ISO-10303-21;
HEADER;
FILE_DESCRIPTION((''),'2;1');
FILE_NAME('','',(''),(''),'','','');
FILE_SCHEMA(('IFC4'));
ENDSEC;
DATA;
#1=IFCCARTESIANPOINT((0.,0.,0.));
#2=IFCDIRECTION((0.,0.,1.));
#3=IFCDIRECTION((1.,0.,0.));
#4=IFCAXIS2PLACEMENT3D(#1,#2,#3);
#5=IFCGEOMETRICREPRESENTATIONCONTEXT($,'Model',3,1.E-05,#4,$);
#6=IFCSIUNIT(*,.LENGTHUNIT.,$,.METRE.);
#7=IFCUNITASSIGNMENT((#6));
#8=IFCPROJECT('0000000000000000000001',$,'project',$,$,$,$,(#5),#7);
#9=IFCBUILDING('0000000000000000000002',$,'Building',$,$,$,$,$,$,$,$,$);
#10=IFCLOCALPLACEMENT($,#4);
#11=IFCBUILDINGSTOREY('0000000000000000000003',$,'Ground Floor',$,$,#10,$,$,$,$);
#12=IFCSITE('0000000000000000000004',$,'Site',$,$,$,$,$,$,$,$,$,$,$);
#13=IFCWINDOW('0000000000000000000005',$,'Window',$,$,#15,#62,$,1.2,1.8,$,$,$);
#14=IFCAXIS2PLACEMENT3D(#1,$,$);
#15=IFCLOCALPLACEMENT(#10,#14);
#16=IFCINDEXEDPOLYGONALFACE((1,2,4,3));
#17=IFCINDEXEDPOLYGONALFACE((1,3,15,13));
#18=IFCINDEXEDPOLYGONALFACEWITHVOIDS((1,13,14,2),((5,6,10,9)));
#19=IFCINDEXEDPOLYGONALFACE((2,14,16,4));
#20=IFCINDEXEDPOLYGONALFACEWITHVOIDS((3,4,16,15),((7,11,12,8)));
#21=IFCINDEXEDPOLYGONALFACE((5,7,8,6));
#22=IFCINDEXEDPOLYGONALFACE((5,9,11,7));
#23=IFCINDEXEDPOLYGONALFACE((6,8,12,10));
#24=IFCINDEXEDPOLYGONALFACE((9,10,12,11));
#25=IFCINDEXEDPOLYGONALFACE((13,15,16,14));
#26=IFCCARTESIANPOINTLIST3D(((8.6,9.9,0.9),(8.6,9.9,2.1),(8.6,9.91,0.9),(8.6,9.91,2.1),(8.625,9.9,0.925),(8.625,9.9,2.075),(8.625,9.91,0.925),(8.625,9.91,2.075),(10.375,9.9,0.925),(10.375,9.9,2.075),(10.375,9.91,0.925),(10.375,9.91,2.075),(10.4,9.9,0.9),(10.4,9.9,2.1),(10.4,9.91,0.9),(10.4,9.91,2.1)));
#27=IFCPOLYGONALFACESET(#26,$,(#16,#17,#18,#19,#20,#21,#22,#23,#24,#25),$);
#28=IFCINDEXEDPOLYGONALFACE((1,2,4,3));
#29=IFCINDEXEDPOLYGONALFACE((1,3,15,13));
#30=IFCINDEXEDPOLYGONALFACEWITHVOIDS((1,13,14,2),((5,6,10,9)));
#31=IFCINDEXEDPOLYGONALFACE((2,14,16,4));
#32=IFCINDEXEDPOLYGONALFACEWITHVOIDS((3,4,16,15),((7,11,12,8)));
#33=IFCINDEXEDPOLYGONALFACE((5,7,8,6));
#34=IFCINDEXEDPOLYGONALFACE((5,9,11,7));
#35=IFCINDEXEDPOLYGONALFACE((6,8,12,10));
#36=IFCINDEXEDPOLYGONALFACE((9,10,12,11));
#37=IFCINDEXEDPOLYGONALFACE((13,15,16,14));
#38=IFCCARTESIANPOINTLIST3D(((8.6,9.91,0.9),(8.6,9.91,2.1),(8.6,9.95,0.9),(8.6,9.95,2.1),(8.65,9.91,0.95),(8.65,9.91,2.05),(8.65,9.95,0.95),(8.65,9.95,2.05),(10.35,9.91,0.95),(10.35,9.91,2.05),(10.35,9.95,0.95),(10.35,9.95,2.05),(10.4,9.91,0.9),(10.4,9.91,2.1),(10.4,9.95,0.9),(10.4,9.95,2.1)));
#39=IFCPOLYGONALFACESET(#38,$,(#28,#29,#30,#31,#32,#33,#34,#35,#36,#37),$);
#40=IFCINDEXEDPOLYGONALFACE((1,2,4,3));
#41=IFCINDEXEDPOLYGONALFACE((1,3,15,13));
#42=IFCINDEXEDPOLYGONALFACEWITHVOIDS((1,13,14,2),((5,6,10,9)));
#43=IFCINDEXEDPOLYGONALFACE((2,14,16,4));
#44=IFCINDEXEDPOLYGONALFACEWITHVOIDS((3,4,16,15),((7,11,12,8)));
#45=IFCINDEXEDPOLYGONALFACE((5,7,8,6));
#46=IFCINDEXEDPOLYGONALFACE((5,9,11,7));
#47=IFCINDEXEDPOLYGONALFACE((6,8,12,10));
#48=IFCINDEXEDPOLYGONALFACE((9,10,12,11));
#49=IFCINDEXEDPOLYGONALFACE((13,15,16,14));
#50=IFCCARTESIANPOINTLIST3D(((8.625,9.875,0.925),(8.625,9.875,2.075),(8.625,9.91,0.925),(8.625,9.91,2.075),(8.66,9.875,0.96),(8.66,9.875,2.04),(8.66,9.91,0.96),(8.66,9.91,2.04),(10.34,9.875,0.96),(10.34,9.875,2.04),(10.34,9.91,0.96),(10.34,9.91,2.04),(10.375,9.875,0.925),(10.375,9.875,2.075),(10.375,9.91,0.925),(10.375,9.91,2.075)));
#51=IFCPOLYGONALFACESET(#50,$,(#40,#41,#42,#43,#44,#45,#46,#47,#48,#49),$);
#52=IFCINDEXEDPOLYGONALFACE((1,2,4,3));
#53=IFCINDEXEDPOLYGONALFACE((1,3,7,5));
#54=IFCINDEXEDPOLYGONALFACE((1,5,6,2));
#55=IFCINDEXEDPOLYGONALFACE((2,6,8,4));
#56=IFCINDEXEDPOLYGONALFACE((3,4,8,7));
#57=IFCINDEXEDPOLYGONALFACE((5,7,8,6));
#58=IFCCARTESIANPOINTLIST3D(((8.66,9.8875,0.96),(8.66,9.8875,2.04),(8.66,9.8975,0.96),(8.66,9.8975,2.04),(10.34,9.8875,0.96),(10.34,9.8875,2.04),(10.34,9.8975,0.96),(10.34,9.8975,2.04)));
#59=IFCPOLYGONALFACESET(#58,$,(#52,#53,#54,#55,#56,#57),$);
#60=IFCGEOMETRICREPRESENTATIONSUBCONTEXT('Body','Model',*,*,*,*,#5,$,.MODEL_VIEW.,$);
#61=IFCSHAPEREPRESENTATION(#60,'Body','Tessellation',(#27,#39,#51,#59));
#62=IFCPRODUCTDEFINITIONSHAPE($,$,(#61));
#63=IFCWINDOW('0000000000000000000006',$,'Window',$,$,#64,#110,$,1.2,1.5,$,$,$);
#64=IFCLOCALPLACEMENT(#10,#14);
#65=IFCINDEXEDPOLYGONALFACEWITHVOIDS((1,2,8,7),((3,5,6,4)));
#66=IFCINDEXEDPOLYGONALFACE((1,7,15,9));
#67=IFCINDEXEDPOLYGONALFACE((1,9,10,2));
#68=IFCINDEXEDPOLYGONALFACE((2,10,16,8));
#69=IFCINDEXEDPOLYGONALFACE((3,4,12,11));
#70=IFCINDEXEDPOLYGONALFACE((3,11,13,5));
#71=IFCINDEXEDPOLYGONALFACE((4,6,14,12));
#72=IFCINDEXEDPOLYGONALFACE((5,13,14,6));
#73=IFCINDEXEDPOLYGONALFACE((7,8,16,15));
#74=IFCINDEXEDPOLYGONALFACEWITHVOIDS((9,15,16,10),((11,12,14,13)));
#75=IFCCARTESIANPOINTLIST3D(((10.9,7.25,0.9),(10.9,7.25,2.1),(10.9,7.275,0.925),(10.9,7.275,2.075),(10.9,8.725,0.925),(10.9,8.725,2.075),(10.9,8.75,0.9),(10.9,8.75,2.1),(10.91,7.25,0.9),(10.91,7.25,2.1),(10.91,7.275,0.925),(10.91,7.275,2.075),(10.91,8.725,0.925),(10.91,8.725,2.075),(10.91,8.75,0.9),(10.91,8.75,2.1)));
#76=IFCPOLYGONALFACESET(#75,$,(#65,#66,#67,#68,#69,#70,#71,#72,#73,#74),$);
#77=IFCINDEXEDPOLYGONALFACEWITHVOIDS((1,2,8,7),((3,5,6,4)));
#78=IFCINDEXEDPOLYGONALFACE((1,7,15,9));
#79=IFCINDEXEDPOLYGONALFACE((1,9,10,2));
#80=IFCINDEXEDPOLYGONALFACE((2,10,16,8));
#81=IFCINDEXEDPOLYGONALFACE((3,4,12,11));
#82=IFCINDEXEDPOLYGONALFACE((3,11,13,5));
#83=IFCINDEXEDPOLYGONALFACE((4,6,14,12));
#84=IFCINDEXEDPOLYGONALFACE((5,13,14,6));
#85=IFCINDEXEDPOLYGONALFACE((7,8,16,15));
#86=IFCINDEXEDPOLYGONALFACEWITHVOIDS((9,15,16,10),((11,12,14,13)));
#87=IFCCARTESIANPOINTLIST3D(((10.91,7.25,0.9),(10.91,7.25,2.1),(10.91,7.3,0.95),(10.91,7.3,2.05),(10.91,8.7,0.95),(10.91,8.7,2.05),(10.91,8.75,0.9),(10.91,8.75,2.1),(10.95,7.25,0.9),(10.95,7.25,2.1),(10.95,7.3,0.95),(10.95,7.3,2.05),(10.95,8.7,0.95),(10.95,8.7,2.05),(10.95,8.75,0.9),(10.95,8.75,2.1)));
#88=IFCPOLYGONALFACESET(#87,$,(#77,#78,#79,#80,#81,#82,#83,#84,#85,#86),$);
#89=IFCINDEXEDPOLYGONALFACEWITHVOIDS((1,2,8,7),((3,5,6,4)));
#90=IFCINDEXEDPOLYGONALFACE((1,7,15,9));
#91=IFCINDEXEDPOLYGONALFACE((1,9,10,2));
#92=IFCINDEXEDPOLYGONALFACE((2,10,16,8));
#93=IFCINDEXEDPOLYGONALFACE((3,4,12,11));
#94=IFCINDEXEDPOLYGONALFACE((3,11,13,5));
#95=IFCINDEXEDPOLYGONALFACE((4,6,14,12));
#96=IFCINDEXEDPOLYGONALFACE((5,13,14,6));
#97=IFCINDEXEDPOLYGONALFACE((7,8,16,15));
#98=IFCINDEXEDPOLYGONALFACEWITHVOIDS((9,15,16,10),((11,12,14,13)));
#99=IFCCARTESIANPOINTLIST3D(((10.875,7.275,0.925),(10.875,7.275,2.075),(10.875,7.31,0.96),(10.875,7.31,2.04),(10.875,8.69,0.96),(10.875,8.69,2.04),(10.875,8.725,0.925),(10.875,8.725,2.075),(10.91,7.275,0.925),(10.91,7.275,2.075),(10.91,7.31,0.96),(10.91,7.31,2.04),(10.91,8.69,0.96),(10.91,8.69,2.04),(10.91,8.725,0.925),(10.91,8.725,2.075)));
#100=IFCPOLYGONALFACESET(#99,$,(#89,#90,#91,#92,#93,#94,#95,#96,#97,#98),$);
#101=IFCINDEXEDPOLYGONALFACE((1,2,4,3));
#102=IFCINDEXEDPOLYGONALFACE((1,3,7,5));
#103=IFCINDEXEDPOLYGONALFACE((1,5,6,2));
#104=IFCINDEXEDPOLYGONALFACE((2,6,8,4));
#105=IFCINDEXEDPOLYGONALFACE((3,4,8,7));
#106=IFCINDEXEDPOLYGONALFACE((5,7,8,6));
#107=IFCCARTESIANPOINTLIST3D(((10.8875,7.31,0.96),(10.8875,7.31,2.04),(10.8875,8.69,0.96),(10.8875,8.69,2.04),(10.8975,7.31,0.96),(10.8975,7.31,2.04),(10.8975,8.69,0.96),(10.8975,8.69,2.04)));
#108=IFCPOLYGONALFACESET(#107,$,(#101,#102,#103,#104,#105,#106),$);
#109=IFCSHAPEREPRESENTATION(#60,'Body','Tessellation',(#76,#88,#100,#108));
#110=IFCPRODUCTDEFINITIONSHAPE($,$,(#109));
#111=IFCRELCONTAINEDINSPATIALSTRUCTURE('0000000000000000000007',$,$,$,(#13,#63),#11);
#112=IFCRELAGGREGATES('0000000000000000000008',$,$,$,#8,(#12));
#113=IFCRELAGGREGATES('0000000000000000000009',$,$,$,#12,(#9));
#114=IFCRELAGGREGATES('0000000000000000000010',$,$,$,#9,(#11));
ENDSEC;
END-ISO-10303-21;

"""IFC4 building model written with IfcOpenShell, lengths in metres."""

from ifc_helpers import new_model, si_unit, frame, origin_with_axes, place, context, subcontext, project, spatial, line, indexed_curve, outline, extrude, element, save


model = new_model("IFC4")

# Units and contexts
model_context = context("Model", 3, precision=1e-05, world=origin_with_axes())
body_context = subcontext(model_context, "Body", "Model", "MODEL_VIEW")
ifc_project = project(units=[si_unit("LENGTHUNIT", "METRE")], contexts=[model_context])

# Site, building, storey
site = spatial("IfcSite", under=ifc_project, Name="Site")
building = spatial("IfcBuilding", under=site, Name="Building")
storey_placement = place(None, origin_with_axes())
storey = spatial("IfcBuildingStorey", under=building, at=storey_placement, Name="Ground Floor")

# Windows
window_1_placement = place(storey_placement, frame((10.4, 10.0, 0.9), z_axis=(0.0, 0.0, 1.0), x_axis=(-1.0, 0.0, 0.0)))
element("IfcWindow", 1, at=window_1_placement, inside=storey, Name="Window", OverallHeight=1.2, OverallWidth=1.8, context=body_context, shape_type="SweptSolid", body=[
    extrude(outline(indexed_curve([(0.0, 0.0), (1.8, 0.0), (1.8, 1.2), (0.0, 1.2)], segments=[line(1, 2, 3, 4, 1)]), holes=[indexed_curve([(0.025, 0.025), (1.775, 0.025), (1.775, 1.175), (0.025, 1.175)], segments=[line(1, 2, 3, 4, 1)])]), frame((0.0, 0.09, 0.0), z_axis=(0.0, -1.0, 0.0), x_axis=(1.0, 0.0, 0.0)), (0.0, 0.0, -1.0), 0.01),
    extrude(outline(indexed_curve([(0.0, 0.0), (1.8, 0.0), (1.8, 1.2), (0.0, 1.2)], segments=[line(1, 2, 3, 4, 1)]), holes=[indexed_curve([(0.05, 0.05), (1.75, 0.05), (1.75, 1.15), (0.05, 1.15)], segments=[line(1, 2, 3, 4, 1)])]), frame((0.0, 0.05, 0.0), z_axis=(0.0, -1.0, 0.0), x_axis=(1.0, 0.0, 0.0)), (0.0, 0.0, -1.0), 0.04),
    extrude(outline(indexed_curve([(0.0, 0.0), (1.75, 0.0), (1.75, 1.15), (0.0, 1.15)], segments=[line(1, 2, 3, 4, 1)]), holes=[indexed_curve([(0.035, 0.035), (1.715, 0.035), (1.715, 1.115), (0.035, 1.115)], segments=[line(1, 2, 3, 4, 1)])]), frame((0.025, 0.09, 0.025), z_axis=(0.0, -1.0, 0.0), x_axis=(1.0, 0.0, 0.0)), (0.0, 0.0, -1.0), 0.035),
    extrude(outline(indexed_curve([(0.035, 0.035), (1.715, 0.035), (1.715, 1.115), (0.035, 1.115)], segments=[line(1, 2, 3, 4, 1)])), frame((0.025, 0.1025, 0.025), z_axis=(0.0, -1.0, 0.0), x_axis=(1.0, 0.0, 0.0)), (0.0, 0.0, -1.0), 0.01),
])
window_2_placement = place(storey_placement, frame((11.0, 7.25, 0.9), z_axis=(0.0, 0.0, 1.0), x_axis=(0.0, 1.0, 0.0)))
element("IfcWindow", 2, at=window_2_placement, inside=storey, Name="Window", OverallHeight=1.2, OverallWidth=1.5, context=body_context, shape_type="SweptSolid", body=[
    extrude(outline(indexed_curve([(0.0, 0.0), (1.5, 0.0), (1.5, 1.2), (0.0, 1.2)], segments=[line(1, 2, 3, 4, 1)]), holes=[indexed_curve([(0.025, 0.025), (1.475, 0.025), (1.475, 1.175), (0.025, 1.175)], segments=[line(1, 2, 3, 4, 1)])]), frame((0.0, 0.09, 0.0), z_axis=(0.0, -1.0, 0.0), x_axis=(1.0, 0.0, 0.0)), (0.0, 0.0, -1.0), 0.01),
    extrude(outline(indexed_curve([(0.0, 0.0), (1.5, 0.0), (1.5, 1.2), (0.0, 1.2)], segments=[line(1, 2, 3, 4, 1)]), holes=[indexed_curve([(0.05, 0.05), (1.45, 0.05), (1.45, 1.15), (0.05, 1.15)], segments=[line(1, 2, 3, 4, 1)])]), frame((0.0, 0.05, 0.0), z_axis=(0.0, -1.0, 0.0), x_axis=(1.0, 0.0, 0.0)), (0.0, 0.0, -1.0), 0.04),
    extrude(outline(indexed_curve([(0.0, 0.0), (1.45, 0.0), (1.45, 1.15), (0.0, 1.15)], segments=[line(1, 2, 3, 4, 1)]), holes=[indexed_curve([(0.035, 0.035), (1.415, 0.035), (1.415, 1.115), (0.035, 1.115)], segments=[line(1, 2, 3, 4, 1)])]), frame((0.025, 0.09, 0.025), z_axis=(0.0, -1.0, 0.0), x_axis=(1.0, 0.0, 0.0)), (0.0, 0.0, -1.0), 0.035),
    extrude(outline(indexed_curve([(0.035, 0.035), (1.415, 0.035), (1.415, 1.115), (0.035, 1.115)], segments=[line(1, 2, 3, 4, 1)])), frame((0.025, 0.1025, 0.025), z_axis=(0.0, -1.0, 0.0), x_axis=(1.0, 0.0, 0.0)), (0.0, 0.0, -1.0), 0.01),
])

save(model, "model.ifc")
